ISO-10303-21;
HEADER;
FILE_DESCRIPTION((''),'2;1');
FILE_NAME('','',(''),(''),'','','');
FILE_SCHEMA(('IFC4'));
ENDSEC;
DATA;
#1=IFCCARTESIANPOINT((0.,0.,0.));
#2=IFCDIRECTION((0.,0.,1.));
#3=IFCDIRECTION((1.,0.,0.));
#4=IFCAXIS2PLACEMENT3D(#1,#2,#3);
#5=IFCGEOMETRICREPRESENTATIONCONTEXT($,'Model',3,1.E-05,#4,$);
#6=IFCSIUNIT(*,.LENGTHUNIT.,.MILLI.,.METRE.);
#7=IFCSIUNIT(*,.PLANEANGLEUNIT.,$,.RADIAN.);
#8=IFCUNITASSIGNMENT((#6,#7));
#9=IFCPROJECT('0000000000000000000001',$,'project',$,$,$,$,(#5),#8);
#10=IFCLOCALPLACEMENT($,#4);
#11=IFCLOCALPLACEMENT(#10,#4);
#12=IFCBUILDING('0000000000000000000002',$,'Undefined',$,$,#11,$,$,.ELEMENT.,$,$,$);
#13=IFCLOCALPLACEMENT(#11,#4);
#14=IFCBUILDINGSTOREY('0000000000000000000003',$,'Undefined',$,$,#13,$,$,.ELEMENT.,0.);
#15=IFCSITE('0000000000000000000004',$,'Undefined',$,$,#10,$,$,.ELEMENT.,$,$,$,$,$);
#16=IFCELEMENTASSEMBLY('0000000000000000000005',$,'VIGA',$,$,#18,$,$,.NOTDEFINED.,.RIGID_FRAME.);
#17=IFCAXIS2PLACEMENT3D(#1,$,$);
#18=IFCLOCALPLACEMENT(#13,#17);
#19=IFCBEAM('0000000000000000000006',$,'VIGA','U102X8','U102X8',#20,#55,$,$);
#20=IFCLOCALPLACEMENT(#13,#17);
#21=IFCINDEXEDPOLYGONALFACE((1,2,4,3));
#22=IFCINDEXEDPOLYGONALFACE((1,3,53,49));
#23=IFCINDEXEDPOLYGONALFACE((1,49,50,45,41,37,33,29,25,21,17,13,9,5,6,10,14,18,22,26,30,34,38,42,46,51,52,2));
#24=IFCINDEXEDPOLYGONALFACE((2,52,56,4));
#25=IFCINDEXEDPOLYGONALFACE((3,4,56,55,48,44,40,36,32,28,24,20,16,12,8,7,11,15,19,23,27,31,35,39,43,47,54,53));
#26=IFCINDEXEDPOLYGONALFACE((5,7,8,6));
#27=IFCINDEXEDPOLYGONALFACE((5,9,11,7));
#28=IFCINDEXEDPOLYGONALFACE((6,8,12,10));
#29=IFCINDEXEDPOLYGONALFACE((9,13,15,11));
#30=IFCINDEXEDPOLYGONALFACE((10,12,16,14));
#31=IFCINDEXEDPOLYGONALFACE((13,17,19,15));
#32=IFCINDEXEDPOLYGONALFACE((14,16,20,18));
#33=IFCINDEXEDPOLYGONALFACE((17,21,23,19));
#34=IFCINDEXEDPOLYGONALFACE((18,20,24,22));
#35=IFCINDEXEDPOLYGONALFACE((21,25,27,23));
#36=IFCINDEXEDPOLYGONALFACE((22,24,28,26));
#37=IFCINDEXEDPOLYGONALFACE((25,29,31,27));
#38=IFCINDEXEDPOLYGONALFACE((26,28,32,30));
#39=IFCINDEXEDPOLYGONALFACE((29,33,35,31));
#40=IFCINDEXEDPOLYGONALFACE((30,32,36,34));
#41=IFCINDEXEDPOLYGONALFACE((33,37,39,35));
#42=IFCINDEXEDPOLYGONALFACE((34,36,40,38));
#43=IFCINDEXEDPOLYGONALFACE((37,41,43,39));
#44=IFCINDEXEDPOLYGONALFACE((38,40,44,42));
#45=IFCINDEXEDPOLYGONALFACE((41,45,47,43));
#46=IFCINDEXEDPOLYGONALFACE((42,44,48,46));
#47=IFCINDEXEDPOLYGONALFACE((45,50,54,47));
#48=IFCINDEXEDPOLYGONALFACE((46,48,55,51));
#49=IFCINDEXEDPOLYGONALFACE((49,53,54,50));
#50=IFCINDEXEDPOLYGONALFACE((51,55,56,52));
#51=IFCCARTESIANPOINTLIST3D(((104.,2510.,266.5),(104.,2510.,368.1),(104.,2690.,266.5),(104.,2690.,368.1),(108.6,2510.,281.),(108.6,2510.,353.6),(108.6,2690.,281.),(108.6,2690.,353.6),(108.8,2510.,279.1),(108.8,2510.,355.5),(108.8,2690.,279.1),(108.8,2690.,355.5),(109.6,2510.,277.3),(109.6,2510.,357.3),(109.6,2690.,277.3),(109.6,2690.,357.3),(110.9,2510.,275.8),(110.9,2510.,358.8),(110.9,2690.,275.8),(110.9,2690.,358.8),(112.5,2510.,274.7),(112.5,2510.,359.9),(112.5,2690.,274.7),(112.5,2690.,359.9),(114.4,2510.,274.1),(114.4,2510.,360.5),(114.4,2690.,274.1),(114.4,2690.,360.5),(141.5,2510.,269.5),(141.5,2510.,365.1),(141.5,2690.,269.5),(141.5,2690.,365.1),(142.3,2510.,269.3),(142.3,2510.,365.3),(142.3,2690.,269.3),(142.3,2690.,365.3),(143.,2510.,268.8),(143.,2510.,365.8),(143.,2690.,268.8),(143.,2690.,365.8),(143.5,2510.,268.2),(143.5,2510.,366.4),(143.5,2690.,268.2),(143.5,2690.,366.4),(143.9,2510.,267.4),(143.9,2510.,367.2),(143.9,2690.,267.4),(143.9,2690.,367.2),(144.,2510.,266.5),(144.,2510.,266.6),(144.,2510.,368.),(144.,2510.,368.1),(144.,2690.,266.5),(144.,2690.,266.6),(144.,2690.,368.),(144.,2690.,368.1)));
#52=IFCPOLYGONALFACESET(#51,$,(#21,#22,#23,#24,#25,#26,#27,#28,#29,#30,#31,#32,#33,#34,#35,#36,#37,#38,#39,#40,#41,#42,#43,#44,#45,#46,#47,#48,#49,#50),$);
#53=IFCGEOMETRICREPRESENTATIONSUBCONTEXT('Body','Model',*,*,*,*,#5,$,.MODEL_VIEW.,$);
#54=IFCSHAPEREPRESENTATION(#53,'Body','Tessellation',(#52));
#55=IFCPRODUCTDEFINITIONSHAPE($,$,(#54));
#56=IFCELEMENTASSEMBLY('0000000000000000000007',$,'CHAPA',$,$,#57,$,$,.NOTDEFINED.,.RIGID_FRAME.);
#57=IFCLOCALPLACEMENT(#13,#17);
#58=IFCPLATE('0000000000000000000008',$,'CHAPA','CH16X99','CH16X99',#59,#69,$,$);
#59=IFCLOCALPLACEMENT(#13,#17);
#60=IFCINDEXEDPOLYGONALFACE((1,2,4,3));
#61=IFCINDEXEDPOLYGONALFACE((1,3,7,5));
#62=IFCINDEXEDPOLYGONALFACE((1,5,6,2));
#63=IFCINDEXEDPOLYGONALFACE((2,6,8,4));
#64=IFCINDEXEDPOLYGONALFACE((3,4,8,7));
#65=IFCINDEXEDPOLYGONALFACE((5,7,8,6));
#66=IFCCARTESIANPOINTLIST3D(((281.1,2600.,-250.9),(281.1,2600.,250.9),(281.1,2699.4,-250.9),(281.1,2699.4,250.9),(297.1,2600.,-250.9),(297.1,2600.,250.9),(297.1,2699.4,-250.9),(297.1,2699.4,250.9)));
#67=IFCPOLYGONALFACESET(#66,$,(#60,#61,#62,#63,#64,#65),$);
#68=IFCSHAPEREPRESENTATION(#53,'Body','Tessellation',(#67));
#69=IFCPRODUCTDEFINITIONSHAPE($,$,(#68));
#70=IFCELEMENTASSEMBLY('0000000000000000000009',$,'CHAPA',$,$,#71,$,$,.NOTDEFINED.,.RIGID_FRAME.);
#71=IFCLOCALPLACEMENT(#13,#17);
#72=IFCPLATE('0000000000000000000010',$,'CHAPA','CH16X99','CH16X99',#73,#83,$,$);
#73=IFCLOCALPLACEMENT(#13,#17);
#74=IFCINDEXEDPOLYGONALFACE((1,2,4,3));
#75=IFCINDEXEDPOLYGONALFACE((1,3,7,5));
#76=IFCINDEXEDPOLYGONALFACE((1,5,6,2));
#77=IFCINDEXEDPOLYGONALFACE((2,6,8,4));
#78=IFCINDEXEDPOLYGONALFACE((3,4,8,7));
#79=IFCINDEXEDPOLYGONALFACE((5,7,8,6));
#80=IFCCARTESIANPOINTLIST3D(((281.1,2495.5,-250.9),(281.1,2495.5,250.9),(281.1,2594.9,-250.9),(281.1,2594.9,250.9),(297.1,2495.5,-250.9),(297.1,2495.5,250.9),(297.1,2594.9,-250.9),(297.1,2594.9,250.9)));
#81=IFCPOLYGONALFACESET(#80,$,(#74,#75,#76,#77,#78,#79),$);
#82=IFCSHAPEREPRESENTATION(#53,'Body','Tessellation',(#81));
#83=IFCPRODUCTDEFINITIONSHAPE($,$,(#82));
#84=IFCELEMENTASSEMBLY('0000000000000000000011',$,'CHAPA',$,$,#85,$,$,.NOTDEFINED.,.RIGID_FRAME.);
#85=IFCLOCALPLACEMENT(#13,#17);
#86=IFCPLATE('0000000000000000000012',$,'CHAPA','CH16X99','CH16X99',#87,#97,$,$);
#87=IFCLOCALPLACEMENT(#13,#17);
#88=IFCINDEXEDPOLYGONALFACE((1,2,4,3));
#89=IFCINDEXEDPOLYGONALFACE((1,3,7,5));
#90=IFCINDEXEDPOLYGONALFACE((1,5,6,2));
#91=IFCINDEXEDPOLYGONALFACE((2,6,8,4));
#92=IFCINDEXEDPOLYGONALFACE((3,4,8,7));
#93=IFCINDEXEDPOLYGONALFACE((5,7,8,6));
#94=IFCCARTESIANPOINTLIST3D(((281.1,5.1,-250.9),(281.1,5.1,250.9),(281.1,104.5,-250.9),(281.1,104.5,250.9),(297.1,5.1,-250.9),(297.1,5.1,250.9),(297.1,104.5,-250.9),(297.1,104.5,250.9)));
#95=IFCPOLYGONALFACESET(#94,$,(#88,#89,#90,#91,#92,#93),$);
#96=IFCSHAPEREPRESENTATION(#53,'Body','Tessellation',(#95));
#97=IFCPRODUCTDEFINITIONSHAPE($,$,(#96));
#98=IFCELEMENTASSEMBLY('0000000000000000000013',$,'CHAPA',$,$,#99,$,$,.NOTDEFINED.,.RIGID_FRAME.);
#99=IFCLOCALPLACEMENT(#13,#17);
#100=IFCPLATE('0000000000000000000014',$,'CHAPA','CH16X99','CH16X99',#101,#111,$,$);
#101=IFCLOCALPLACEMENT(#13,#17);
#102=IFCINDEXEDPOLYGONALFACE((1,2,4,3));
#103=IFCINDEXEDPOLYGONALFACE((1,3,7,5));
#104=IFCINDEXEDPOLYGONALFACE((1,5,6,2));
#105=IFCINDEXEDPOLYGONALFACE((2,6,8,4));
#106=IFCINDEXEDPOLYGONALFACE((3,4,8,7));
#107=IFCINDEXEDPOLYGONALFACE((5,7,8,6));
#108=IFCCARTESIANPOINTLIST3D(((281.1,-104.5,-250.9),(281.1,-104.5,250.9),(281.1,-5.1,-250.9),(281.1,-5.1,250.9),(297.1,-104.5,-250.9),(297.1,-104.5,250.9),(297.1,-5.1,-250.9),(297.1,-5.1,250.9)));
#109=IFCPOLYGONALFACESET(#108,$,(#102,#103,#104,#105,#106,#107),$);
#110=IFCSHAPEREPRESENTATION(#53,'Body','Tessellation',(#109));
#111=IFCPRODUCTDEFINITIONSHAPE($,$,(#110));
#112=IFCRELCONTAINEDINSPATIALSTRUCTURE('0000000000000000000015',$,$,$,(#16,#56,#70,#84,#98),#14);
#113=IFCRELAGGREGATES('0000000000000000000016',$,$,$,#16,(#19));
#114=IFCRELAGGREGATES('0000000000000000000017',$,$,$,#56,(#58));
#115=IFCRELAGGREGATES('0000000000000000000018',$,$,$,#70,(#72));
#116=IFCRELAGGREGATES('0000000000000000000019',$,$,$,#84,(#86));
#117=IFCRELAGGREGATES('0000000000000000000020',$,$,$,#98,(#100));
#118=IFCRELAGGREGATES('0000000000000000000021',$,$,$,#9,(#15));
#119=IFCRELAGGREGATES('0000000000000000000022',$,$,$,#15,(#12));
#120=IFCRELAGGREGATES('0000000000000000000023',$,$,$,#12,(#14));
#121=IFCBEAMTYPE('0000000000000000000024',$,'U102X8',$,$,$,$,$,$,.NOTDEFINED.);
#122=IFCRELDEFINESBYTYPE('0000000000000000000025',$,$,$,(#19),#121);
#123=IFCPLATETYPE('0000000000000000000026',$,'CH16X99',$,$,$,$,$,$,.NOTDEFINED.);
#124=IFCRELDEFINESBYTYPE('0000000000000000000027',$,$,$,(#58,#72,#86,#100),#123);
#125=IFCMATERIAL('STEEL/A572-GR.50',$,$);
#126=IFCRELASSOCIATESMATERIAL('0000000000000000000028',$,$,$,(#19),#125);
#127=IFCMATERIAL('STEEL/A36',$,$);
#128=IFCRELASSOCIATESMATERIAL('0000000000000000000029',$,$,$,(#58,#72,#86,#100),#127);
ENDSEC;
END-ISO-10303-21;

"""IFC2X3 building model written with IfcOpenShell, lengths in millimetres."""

from ifc_helpers import new_model, si_unit, frame, origin_with_axes, origin_2d_with_axis, place, context, subcontext, project, spatial, polyline, u_section, outline, extrude, material, type_object, element, aggregate, save


model = new_model("IFC2X3")

# Units and contexts
model_context = context("Model", 3, precision=1e-05, world=origin_with_axes())
body_context = subcontext(model_context, "Body", "Model", "MODEL_VIEW")
ifc_project = project(units=[si_unit("LENGTHUNIT", "METRE", prefix="MILLI"), si_unit("PLANEANGLEUNIT", "RADIAN")], contexts=[model_context])

# Site, building, storey
site_placement = place(None, origin_with_axes())
site = spatial("IfcSite", under=ifc_project, at=site_placement, Name="Undefined", CompositionType="ELEMENT")
building_placement = place(site_placement, origin_with_axes())
building = spatial("IfcBuilding", under=site, at=building_placement, Name="Undefined", CompositionType="ELEMENT")
storey_placement = place(building_placement, origin_with_axes())
storey = spatial("IfcBuildingStorey", under=building, at=storey_placement, Name="Undefined", CompositionType="ELEMENT", Elevation=0.0)

# Element assembly, beam
ifc_material_1 = material(Name="STEEL/A572-GR.50")
beam_type_1 = type_object("IfcBeamType", Name="U102X8", PredefinedType="NOTDEFINED")
assembly_1_placement = place(storey_placement, origin_with_axes())
assembly_1 = element("IfcElementAssembly", 1, at=assembly_1_placement, inside=storey, Name="VIGA", AssemblyPlace="NOTDEFINED", PredefinedType="RIGID_FRAME")
beam_1_placement = place(assembly_1_placement, frame((124.0, 2510.0, 317.3), z_axis=(0.0, 0.0, 1.0), x_axis=(0.0, 1.0, 0.0)))
beam_1 = element("IfcBeam", 2, at=beam_1_placement, type_object=beam_type_1, material=ifc_material_1, Name="VIGA", Description="U102X8", ObjectType="U102X8", context=body_context, shape_type="SweptSolid", body=[
    extrude(u_section(Depth=101.6, FlangeWidth=40.0, WebThickness=4.6, FlangeThickness=6.0, FilletRadius=7.0, EdgeRadius=3.0, FlangeSlope=0.16839, at=origin_2d_with_axis()), frame((180.0, 0.0, 0.0), z_axis=(-1.0, 0.0, 0.0), x_axis=(0.0, -1.0, 0.0)), (0.0, 0.0, 1.0), 180.0),
])
aggregate(assembly_1, [beam_1])

# Element assemblies, plates
assembly_2_placement = place(storey_placement, origin_with_axes())
assembly_2 = element("IfcElementAssembly", 3, at=assembly_2_placement, inside=storey, Name="CHAPA", AssemblyPlace="NOTDEFINED", PredefinedType="RIGID_FRAME")
ifc_material_2 = material(Name="STEEL/A36")
plate_type = type_object("IfcPlateType", Name="CH16X99", PredefinedType="NOTDEFINED")
plate_1_placement = place(assembly_2_placement, frame((289.1, 2600.0, 250.9), z_axis=(-1.0, 0.0, 0.0), x_axis=(0.0, 1.0, 0.0)))
plate_1 = element("IfcPlate", 4, at=plate_1_placement, type_object=plate_type, material=ifc_material_2, Name="CHAPA", Description="CH16X99", ObjectType="CH16X99", context=body_context, shape_type="SweptSolid", body=[
    extrude(outline(polyline([(0.0, 0.0), (99.4, 0.0), (99.4, 501.8), (0.0, 501.8), (0.0, 0.0)])), frame((0.0, 0.0, -8.0), z_axis=(0.0, 0.0, 1.0), x_axis=(1.0, 0.0, 0.0)), (0.0, 0.0, 1.0), 16.0),
])
aggregate(assembly_2, [plate_1])
assembly_3_placement = place(storey_placement, origin_with_axes())
assembly_3 = element("IfcElementAssembly", 5, at=assembly_3_placement, inside=storey, Name="CHAPA", AssemblyPlace="NOTDEFINED", PredefinedType="RIGID_FRAME")
plate_2_placement = place(assembly_3_placement, frame((289.1, 2495.5, 250.9), z_axis=(-1.0, 0.0, 0.0), x_axis=(0.0, 1.0, 0.0)))
plate_2 = element("IfcPlate", 6, at=plate_2_placement, type_object=plate_type, material=ifc_material_2, Name="CHAPA", Description="CH16X99", ObjectType="CH16X99", context=body_context, shape_type="SweptSolid", body=[
    extrude(outline(polyline([(0.0, 0.0), (99.4, 0.0), (99.4, 501.8), (0.0, 501.8), (0.0, 0.0)])), frame((0.0, 0.0, -8.0), z_axis=(0.0, 0.0, 1.0), x_axis=(1.0, 0.0, 0.0)), (0.0, 0.0, 1.0), 16.0),
])
aggregate(assembly_3, [plate_2])
assembly_4_placement = place(storey_placement, origin_with_axes())
assembly_4 = element("IfcElementAssembly", 7, at=assembly_4_placement, inside=storey, Name="CHAPA", AssemblyPlace="NOTDEFINED", PredefinedType="RIGID_FRAME")
plate_3_placement = place(assembly_4_placement, frame((289.1, 5.1, 250.9), z_axis=(-1.0, 0.0, 0.0), x_axis=(0.0, 1.0, 0.0)))
plate_3 = element("IfcPlate", 8, at=plate_3_placement, type_object=plate_type, material=ifc_material_2, Name="CHAPA", Description="CH16X99", ObjectType="CH16X99", context=body_context, shape_type="SweptSolid", body=[
    extrude(outline(polyline([(0.0, 0.0), (99.4, 0.0), (99.4, 501.8), (0.0, 501.8), (0.0, 0.0)])), frame((0.0, 0.0, -8.0), z_axis=(0.0, 0.0, 1.0), x_axis=(1.0, 0.0, 0.0)), (0.0, 0.0, 1.0), 16.0),
])
aggregate(assembly_4, [plate_3])
assembly_5_placement = place(storey_placement, origin_with_axes())
assembly_5 = element("IfcElementAssembly", 9, at=assembly_5_placement, inside=storey, Name="CHAPA", AssemblyPlace="NOTDEFINED", PredefinedType="RIGID_FRAME")
plate_4_placement = place(assembly_5_placement, frame((289.1, -104.5, 250.9), z_axis=(-1.0, 0.0, 0.0), x_axis=(0.0, 1.0, 0.0)))
plate_4 = element("IfcPlate", 10, at=plate_4_placement, type_object=plate_type, material=ifc_material_2, Name="CHAPA", Description="CH16X99", ObjectType="CH16X99", context=body_context, shape_type="SweptSolid", body=[
    extrude(outline(polyline([(0.0, 0.0), (99.4, 0.0), (99.4, 501.8), (0.0, 501.8), (0.0, 0.0)])), frame((0.0, 0.0, -8.0), z_axis=(0.0, 0.0, 1.0), x_axis=(1.0, 0.0, 0.0)), (0.0, 0.0, 1.0), 16.0),
])
aggregate(assembly_5, [plate_4])

save(model, "model.ifc")
